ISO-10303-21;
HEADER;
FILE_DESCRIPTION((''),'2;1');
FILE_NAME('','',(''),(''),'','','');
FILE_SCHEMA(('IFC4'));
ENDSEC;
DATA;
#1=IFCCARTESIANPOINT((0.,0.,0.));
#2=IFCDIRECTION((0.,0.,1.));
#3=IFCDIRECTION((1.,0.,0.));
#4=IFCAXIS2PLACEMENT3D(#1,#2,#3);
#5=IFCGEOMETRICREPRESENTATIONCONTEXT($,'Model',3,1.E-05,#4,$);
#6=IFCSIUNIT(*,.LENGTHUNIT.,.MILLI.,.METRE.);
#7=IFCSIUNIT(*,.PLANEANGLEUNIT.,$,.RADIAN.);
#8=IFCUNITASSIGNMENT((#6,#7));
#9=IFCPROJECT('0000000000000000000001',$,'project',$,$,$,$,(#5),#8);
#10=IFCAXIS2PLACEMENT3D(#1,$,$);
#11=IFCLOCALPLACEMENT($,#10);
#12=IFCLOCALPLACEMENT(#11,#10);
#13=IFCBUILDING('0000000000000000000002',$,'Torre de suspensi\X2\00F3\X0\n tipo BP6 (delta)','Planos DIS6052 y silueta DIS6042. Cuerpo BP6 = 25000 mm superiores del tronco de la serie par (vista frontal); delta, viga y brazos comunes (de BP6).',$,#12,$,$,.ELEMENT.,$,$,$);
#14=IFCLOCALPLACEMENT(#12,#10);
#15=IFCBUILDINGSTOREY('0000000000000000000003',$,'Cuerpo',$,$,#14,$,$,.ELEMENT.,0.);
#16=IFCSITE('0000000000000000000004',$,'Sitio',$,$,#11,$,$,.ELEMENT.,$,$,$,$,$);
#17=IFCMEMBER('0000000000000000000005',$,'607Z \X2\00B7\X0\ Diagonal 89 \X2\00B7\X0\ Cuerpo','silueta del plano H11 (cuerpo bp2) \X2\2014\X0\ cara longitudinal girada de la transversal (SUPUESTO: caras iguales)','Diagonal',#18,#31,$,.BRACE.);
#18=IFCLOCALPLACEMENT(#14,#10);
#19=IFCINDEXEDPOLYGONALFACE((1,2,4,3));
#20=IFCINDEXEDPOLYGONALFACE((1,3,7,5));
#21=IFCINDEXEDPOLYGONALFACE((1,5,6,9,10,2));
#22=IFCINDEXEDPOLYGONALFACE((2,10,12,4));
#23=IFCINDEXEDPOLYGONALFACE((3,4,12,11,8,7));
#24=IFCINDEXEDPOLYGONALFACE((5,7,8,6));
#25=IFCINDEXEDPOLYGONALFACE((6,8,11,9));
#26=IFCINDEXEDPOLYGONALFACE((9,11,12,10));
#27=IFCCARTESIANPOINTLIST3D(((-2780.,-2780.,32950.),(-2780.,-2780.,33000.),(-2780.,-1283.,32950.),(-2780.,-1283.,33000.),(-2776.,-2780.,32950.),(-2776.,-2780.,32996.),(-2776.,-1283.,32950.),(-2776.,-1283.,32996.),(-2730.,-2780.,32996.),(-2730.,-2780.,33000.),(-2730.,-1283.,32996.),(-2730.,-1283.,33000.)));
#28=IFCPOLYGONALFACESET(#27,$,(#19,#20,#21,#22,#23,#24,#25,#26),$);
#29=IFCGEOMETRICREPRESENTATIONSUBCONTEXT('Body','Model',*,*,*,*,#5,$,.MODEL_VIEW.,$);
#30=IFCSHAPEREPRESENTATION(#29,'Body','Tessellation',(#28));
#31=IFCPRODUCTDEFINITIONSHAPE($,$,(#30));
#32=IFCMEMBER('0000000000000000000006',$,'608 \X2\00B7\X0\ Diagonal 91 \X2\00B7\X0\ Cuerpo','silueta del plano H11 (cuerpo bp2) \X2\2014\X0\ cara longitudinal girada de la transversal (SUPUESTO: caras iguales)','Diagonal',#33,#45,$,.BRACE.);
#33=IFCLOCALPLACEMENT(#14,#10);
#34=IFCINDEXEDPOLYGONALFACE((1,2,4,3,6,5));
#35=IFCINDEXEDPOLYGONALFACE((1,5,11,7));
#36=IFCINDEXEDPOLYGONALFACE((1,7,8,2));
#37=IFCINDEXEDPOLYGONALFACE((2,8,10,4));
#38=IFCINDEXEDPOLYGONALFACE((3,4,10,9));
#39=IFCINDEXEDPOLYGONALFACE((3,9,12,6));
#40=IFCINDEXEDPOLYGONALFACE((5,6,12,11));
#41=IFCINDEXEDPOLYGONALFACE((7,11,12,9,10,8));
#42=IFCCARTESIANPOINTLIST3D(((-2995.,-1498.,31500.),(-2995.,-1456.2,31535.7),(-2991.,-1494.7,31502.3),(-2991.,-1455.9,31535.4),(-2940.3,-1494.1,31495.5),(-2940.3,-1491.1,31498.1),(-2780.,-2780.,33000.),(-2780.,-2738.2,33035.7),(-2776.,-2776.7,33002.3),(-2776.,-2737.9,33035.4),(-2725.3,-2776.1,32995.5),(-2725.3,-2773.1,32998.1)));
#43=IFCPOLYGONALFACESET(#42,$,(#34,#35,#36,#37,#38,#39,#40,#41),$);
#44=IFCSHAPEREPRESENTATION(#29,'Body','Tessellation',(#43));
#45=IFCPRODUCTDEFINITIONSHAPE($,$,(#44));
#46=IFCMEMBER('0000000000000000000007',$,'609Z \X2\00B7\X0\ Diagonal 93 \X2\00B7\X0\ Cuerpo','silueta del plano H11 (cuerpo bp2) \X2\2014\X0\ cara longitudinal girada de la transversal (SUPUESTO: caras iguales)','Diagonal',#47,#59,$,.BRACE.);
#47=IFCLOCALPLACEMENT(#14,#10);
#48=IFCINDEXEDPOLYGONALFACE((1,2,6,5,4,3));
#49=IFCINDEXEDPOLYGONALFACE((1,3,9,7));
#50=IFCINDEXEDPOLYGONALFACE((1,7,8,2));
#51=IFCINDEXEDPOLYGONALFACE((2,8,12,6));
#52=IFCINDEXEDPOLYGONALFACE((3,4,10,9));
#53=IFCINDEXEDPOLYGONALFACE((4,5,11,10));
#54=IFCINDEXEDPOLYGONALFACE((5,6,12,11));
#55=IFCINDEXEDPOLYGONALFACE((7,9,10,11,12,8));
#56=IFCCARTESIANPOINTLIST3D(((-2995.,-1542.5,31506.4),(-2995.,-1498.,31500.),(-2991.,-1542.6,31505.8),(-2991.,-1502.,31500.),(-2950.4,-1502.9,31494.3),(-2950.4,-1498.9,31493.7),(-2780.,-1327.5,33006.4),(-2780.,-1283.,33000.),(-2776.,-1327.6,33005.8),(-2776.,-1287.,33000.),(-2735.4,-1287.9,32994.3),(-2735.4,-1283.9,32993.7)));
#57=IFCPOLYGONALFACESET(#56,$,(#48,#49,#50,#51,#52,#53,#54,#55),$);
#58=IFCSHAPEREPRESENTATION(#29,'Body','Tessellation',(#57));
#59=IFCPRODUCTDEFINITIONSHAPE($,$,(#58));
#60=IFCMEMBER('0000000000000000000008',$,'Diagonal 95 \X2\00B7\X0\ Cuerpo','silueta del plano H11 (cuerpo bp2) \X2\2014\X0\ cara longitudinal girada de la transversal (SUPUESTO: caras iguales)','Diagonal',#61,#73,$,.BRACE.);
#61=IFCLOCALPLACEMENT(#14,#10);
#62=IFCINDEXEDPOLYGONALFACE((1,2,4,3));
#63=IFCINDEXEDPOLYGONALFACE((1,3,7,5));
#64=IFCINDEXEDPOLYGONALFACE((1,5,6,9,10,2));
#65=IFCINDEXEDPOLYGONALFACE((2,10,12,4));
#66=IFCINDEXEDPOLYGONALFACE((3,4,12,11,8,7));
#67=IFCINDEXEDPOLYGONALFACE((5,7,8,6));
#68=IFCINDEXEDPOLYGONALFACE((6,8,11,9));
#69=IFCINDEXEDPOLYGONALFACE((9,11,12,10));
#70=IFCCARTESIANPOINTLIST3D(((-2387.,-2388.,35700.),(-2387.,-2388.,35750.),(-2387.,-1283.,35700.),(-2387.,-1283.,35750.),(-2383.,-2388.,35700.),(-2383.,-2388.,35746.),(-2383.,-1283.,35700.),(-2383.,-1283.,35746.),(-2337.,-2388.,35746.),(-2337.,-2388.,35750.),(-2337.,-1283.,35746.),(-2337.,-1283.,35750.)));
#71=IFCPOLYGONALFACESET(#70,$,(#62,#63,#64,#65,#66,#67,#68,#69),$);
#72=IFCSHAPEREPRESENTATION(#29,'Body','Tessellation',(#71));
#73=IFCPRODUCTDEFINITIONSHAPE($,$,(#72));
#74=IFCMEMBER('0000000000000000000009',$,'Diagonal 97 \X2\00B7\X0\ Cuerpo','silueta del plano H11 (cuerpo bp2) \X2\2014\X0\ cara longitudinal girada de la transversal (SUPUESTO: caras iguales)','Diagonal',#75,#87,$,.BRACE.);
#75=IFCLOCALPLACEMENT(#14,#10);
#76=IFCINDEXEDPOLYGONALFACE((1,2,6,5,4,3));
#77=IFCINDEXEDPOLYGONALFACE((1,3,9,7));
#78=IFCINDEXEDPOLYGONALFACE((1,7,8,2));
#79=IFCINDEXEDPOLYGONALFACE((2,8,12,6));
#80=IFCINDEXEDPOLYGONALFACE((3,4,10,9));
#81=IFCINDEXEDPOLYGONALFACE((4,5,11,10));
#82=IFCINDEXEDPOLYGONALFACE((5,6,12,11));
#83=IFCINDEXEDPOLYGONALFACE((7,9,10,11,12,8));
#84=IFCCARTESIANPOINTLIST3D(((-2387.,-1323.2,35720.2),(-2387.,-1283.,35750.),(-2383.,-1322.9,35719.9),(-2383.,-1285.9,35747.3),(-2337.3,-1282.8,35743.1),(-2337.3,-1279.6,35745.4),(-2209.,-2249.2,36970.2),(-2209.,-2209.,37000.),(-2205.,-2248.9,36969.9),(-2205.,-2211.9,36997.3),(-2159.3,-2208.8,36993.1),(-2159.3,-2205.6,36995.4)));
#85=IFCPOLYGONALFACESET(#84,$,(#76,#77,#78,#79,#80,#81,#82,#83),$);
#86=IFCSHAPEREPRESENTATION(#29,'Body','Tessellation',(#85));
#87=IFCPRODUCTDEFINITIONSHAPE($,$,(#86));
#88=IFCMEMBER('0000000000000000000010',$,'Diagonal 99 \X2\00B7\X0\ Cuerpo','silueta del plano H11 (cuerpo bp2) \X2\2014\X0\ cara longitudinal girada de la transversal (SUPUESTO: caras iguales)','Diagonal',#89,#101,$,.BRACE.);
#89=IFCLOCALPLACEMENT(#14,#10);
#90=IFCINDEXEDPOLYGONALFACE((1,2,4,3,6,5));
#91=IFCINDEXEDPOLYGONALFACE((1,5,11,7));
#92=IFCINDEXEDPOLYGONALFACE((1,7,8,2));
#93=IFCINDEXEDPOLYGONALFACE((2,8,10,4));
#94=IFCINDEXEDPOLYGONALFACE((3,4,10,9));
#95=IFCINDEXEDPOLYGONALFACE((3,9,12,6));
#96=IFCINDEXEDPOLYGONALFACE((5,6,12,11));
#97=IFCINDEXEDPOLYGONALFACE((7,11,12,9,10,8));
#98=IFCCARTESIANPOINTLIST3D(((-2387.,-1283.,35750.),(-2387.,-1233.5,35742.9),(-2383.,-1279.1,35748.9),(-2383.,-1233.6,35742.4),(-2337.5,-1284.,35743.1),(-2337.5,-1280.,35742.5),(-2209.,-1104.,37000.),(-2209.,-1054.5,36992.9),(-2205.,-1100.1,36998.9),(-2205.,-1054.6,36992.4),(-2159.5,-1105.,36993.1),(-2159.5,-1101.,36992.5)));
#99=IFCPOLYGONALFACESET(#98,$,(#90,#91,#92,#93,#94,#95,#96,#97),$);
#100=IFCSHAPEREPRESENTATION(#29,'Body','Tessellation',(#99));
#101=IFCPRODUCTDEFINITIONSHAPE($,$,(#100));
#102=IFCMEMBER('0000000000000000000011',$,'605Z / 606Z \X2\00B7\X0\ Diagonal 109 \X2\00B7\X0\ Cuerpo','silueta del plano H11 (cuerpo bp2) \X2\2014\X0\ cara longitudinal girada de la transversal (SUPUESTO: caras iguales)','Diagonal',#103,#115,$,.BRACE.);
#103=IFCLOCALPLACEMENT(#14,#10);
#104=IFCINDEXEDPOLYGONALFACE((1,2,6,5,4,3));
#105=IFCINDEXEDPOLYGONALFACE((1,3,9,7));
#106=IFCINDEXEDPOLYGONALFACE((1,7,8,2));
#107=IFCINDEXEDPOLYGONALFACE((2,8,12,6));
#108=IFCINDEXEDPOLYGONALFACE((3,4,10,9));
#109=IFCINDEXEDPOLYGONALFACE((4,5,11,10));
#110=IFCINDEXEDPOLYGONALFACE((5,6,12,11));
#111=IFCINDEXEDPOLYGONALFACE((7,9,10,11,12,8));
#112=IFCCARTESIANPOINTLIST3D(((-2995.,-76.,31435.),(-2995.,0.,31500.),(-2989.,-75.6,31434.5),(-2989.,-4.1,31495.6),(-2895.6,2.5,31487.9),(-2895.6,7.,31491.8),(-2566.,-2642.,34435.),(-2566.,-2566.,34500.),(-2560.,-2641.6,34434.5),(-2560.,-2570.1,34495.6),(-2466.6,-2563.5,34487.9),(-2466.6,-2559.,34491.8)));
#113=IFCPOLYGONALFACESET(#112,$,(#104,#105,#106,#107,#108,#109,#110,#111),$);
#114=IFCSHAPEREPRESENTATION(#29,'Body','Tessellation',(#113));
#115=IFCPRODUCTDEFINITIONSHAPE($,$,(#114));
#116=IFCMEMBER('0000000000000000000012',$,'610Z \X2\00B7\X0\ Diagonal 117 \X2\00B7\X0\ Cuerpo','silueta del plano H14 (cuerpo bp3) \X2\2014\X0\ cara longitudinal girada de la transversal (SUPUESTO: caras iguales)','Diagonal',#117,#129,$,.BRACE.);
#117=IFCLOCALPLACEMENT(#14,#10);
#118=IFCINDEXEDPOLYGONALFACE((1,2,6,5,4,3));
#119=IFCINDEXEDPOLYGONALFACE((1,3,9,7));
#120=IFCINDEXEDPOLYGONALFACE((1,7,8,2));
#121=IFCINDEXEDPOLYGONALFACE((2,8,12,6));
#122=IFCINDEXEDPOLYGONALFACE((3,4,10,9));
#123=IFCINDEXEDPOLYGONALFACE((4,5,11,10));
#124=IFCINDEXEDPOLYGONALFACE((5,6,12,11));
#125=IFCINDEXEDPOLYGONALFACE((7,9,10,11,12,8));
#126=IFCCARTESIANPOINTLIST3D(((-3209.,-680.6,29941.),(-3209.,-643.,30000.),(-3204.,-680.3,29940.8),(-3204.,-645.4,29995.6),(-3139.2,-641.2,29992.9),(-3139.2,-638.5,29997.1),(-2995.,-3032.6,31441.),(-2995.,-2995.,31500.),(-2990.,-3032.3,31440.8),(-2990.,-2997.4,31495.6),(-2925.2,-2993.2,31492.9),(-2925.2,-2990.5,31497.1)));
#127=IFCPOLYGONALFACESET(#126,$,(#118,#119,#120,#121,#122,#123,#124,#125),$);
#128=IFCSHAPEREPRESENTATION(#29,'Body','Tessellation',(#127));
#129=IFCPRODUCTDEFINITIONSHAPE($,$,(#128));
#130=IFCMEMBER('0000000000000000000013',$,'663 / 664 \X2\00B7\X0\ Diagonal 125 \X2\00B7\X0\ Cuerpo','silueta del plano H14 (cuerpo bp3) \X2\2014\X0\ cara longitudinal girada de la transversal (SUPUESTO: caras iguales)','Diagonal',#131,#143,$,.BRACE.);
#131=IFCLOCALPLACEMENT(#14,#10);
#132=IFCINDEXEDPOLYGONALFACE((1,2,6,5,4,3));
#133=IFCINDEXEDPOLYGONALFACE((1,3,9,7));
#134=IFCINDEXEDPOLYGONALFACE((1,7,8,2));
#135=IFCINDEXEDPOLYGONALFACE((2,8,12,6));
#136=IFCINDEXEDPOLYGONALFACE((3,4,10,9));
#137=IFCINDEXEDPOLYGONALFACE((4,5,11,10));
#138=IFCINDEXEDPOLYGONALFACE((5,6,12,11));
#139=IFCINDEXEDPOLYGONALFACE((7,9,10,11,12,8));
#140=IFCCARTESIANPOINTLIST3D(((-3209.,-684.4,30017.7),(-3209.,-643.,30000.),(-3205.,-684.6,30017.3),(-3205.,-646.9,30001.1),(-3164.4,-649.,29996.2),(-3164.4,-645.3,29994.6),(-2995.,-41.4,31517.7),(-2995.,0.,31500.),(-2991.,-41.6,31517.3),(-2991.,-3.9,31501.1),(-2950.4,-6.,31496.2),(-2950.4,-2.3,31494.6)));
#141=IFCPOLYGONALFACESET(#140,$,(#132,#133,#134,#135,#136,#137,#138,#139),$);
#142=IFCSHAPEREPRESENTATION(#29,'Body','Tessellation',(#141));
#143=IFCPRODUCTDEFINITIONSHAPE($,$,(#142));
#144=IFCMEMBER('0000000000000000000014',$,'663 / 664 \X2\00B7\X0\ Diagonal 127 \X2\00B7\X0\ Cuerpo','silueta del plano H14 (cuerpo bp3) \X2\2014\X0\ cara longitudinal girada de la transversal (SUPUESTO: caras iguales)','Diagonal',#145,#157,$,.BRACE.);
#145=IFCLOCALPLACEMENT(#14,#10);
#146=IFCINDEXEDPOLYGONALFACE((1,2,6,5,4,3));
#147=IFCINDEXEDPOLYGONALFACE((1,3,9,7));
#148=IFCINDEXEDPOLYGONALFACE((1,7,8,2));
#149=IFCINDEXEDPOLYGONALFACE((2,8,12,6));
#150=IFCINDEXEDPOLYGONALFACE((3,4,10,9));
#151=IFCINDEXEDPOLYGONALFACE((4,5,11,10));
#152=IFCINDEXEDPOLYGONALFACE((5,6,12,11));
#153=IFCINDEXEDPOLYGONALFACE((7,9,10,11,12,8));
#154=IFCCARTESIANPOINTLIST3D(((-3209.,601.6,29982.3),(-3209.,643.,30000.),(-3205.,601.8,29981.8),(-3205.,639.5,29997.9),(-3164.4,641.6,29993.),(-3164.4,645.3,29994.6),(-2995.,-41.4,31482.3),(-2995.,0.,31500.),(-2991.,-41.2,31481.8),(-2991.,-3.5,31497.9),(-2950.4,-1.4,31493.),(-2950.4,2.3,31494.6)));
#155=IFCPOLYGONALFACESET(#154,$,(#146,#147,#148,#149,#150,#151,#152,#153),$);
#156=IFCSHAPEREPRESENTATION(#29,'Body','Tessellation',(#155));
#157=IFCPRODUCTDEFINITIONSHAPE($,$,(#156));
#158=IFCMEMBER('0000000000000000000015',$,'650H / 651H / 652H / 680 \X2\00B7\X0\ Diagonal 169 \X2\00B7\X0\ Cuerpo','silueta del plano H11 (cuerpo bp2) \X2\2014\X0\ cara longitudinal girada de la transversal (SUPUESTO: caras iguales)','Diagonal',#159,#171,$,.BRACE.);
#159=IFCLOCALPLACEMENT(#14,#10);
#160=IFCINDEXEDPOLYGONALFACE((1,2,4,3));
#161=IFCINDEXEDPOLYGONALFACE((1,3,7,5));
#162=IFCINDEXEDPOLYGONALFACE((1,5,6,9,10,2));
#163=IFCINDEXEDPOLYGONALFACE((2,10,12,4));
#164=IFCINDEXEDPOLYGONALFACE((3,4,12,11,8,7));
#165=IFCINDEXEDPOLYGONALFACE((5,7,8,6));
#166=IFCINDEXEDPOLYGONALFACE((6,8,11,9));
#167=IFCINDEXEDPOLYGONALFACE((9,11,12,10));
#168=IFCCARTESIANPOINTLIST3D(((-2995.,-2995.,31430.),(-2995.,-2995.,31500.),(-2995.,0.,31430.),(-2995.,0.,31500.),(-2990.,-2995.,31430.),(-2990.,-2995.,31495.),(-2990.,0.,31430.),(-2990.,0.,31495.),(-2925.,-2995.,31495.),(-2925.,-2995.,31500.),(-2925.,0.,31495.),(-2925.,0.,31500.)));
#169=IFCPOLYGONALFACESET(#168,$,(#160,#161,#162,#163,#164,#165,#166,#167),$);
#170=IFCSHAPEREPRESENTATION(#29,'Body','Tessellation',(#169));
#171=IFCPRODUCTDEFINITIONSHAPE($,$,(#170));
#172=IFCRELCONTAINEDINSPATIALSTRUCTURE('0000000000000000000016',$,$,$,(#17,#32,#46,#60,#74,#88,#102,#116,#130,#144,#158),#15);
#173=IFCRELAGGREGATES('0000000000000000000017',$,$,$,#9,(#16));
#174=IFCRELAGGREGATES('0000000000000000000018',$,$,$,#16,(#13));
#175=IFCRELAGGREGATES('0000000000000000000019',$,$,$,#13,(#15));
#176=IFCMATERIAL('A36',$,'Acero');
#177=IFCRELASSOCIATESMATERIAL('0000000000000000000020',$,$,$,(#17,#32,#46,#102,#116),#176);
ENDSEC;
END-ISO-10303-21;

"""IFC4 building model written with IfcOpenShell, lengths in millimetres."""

from ifc_helpers import new_model, si_unit, frame, frame_2d, origin, origin_with_axes, place, context, subcontext, project, spatial, l_section, extrude, material, element, save


model = new_model("IFC4")

# Units and contexts
model_context = context("Model", 3, precision=1e-05, world=origin_with_axes())
body_context = subcontext(model_context, "Body", "Model", "MODEL_VIEW")
ifc_project = project(units=[si_unit("LENGTHUNIT", "METRE", prefix="MILLI"), si_unit("PLANEANGLEUNIT", "RADIAN")], contexts=[model_context])

# Site, building, storey
site_placement = place(None, origin())
site = spatial("IfcSite", under=ifc_project, at=site_placement, Name="Sitio", CompositionType="ELEMENT")
building_placement = place(site_placement, origin())
building = spatial("IfcBuilding", under=site, at=building_placement, Name="Torre de suspensión tipo BP6 (delta)", Description="Planos DIS6052 y silueta DIS6042. Cuerpo BP6 = 25000 mm superiores del tronco de la serie par (vista frontal); delta, viga y brazos comunes (de BP6).", CompositionType="ELEMENT")
storey_placement = place(building_placement, origin())
storey = spatial("IfcBuildingStorey", under=building, at=storey_placement, Name="Cuerpo", CompositionType="ELEMENT", Elevation=0.0)

# Members
ifc_material_1 = material(Name="A36", Category="Acero")
member_1_placement = place(storey_placement, frame((-2780.0, -2780.0, 33000.0), z_axis=(0.0, 1.0, 0.0), x_axis=(1.0, 0.0, 0.0)))
element("IfcMember", 1, at=member_1_placement, inside=storey, material=ifc_material_1, Name="607Z · Diagonal 89 · Cuerpo", Description="silueta del plano H11 (cuerpo bp2) — cara longitudinal girada de la transversal (SUPUESTO: caras iguales)", ObjectType="Diagonal", PredefinedType="BRACE", context=body_context, shape_type="SweptSolid", body=[
    extrude(l_section(Depth=50.0, Width=50.0, Thickness=4.0, at=frame_2d((25.0, 25.0))), None, (0.0, 0.0, 1.0), 1497.0),
])
member_2_placement = place(storey_placement, frame((-2995.0, -1498.0, 31500.0), z_axis=(0.108319, -0.645883, 0.755713), x_axis=(0.994116, 0.070375, -0.082342)))
element("IfcMember", 2, at=member_2_placement, inside=storey, material=ifc_material_1, Name="608 · Diagonal 91 · Cuerpo", Description="silueta del plano H11 (cuerpo bp2) — cara longitudinal girada de la transversal (SUPUESTO: caras iguales)", ObjectType="Diagonal", PredefinedType="BRACE", context=body_context, shape_type="SweptSolid", body=[
    extrude(l_section(Depth=55.0, Width=55.0, Thickness=4.0, at=frame_2d((27.5, 27.5))), None, (0.0, 0.0, 1.0), 1984.9),
])
member_3_placement = place(storey_placement, frame((-2780.0, -1283.0, 33000.0), z_axis=(-0.140476, -0.140476, -0.980068), x_axis=(0.990084, -0.019931, -0.139055)))
element("IfcMember", 3, at=member_3_placement, inside=storey, material=ifc_material_1, Name="609Z · Diagonal 93 · Cuerpo", Description="silueta del plano H11 (cuerpo bp2) — cara longitudinal girada de la transversal (SUPUESTO: caras iguales)", ObjectType="Diagonal", PredefinedType="BRACE", context=body_context, shape_type="SweptSolid", body=[
    extrude(l_section(Depth=45.0, Width=45.0, Thickness=4.0, at=frame_2d((22.5, 22.5))), None, (0.0, 0.0, 1.0), 1530.5),
])
member_4_placement = place(storey_placement, frame((-2387.0, -2388.0, 35750.0), z_axis=(0.0, 1.0, 0.0), x_axis=(1.0, 0.0, 0.0)))
element("IfcMember", 4, at=member_4_placement, inside=storey, Name="Diagonal 95 · Cuerpo", Description="silueta del plano H11 (cuerpo bp2) — cara longitudinal girada de la transversal (SUPUESTO: caras iguales)", ObjectType="Diagonal", PredefinedType="BRACE", context=body_context, shape_type="SweptSolid", body=[
    extrude(l_section(Depth=50.0, Width=50.0, Thickness=4.0, at=frame_2d((25.0, 25.0))), None, (0.0, 0.0, 1.0), 1105.0),
])
member_5_placement = place(storey_placement, frame((-2209.0, -2209.0, 37000.0), z_axis=(-0.113682, 0.591399, -0.798325), x_axis=(0.993517, 0.06767, -0.091347)))
element("IfcMember", 5, at=member_5_placement, inside=storey, Name="Diagonal 97 · Cuerpo", Description="silueta del plano H11 (cuerpo bp2) — cara longitudinal girada de la transversal (SUPUESTO: caras iguales)", ObjectType="Diagonal", PredefinedType="BRACE", context=body_context, shape_type="SweptSolid", body=[
    extrude(l_section(Depth=50.0, Width=50.0, Thickness=4.0, at=frame_2d((25.0, 25.0))), None, (0.0, 0.0, 1.0), 1565.8),
])
member_6_placement = place(storey_placement, frame((-2387.0, -1283.0, 35750.0), z_axis=(0.139582, 0.140366, 0.980211), x_axis=(0.990211, -0.019786, -0.138173)))
element("IfcMember", 6, at=member_6_placement, inside=storey, Name="Diagonal 99 · Cuerpo", Description="silueta del plano H11 (cuerpo bp2) — cara longitudinal girada de la transversal (SUPUESTO: caras iguales)", ObjectType="Diagonal", PredefinedType="BRACE", context=body_context, shape_type="SweptSolid", body=[
    extrude(l_section(Depth=50.0, Width=50.0, Thickness=4.0, at=frame_2d((25.0, 25.0))), None, (0.0, 0.0, 1.0), 1275.2),
])
member_7_placement = place(storey_placement, frame((-2566.0, -2566.0, 34500.0), z_axis=(-0.108035, 0.646194, -0.755488), x_axis=(0.994147, 0.070222, -0.082099)))
element("IfcMember", 7, at=member_7_placement, inside=storey, material=ifc_material_1, Name="605Z / 606Z · Diagonal 109 · Cuerpo", Description="silueta del plano H11 (cuerpo bp2) — cara longitudinal girada de la transversal (SUPUESTO: caras iguales)", ObjectType="Diagonal", PredefinedType="BRACE", context=body_context, shape_type="SweptSolid", body=[
    extrude(l_section(Depth=100.0, Width=100.0, Thickness=6.0, at=frame_2d((50.0, 50.0))), None, (0.0, 0.0, 1.0), 3970.9),
])
member_8_placement = place(storey_placement, frame((-2995.0, -2995.0, 31500.0), z_axis=(-0.076489, 0.84066, -0.536135), x_axis=(0.99707, 0.06449, -0.041129)))
element("IfcMember", 8, at=member_8_placement, inside=storey, material=ifc_material_1, Name="610Z · Diagonal 117 · Cuerpo", Description="silueta del plano H14 (cuerpo bp3) — cara longitudinal girada de la transversal (SUPUESTO: caras iguales)", ObjectType="Diagonal", PredefinedType="BRACE", context=body_context, shape_type="SweptSolid", body=[
    extrude(l_section(Depth=70.0, Width=70.0, Thickness=5.0, at=frame_2d((35.0, 35.0))), None, (0.0, 0.0, 1.0), 2797.8),
])
for number, where, z_axis, x_axis, name in (
    (9, (-2995.0, 0.0, 31500.0), (-0.130014, -0.390649, -0.911312), (0.991512, -0.051225, -0.119497), "663 / 664 · Diagonal 125 · Cuerpo"),
    (10, (-2995.0, 0.0, 31500.0), (-0.130014, 0.390649, -0.911312), (0.991512, 0.051225, -0.119497), "663 / 664 · Diagonal 127 · Cuerpo"),
):
    element("IfcMember", number, at=place(storey_placement, frame(where, z_axis=z_axis, x_axis=x_axis)), inside=storey, Name=name, Description="silueta del plano H14 (cuerpo bp3) — cara longitudinal girada de la transversal (SUPUESTO: caras iguales)", ObjectType="Diagonal", PredefinedType="BRACE", context=body_context, shape_type="SweptSolid", body=[
        extrude(l_section(Depth=45.0, Width=45.0, Thickness=4.0, at=frame_2d((22.5, 22.5))), None, (0.0, 0.0, 1.0), 1646.0),
    ])
member_9_placement = place(storey_placement, frame((-2995.0, -2995.0, 31500.0), z_axis=(0.0, 1.0, 0.0), x_axis=(1.0, 0.0, 0.0)))
element("IfcMember", 11, at=member_9_placement, inside=storey, Name="650H / 651H / 652H / 680 · Diagonal 169 · Cuerpo", Description="silueta del plano H11 (cuerpo bp2) — cara longitudinal girada de la transversal (SUPUESTO: caras iguales)", ObjectType="Diagonal", PredefinedType="BRACE", context=body_context, shape_type="SweptSolid", body=[
    extrude(l_section(Depth=70.0, Width=70.0, Thickness=5.0, at=frame_2d((35.0, 35.0))), None, (0.0, 0.0, 1.0), 2995.0),
])

save(model, "model.ifc")
